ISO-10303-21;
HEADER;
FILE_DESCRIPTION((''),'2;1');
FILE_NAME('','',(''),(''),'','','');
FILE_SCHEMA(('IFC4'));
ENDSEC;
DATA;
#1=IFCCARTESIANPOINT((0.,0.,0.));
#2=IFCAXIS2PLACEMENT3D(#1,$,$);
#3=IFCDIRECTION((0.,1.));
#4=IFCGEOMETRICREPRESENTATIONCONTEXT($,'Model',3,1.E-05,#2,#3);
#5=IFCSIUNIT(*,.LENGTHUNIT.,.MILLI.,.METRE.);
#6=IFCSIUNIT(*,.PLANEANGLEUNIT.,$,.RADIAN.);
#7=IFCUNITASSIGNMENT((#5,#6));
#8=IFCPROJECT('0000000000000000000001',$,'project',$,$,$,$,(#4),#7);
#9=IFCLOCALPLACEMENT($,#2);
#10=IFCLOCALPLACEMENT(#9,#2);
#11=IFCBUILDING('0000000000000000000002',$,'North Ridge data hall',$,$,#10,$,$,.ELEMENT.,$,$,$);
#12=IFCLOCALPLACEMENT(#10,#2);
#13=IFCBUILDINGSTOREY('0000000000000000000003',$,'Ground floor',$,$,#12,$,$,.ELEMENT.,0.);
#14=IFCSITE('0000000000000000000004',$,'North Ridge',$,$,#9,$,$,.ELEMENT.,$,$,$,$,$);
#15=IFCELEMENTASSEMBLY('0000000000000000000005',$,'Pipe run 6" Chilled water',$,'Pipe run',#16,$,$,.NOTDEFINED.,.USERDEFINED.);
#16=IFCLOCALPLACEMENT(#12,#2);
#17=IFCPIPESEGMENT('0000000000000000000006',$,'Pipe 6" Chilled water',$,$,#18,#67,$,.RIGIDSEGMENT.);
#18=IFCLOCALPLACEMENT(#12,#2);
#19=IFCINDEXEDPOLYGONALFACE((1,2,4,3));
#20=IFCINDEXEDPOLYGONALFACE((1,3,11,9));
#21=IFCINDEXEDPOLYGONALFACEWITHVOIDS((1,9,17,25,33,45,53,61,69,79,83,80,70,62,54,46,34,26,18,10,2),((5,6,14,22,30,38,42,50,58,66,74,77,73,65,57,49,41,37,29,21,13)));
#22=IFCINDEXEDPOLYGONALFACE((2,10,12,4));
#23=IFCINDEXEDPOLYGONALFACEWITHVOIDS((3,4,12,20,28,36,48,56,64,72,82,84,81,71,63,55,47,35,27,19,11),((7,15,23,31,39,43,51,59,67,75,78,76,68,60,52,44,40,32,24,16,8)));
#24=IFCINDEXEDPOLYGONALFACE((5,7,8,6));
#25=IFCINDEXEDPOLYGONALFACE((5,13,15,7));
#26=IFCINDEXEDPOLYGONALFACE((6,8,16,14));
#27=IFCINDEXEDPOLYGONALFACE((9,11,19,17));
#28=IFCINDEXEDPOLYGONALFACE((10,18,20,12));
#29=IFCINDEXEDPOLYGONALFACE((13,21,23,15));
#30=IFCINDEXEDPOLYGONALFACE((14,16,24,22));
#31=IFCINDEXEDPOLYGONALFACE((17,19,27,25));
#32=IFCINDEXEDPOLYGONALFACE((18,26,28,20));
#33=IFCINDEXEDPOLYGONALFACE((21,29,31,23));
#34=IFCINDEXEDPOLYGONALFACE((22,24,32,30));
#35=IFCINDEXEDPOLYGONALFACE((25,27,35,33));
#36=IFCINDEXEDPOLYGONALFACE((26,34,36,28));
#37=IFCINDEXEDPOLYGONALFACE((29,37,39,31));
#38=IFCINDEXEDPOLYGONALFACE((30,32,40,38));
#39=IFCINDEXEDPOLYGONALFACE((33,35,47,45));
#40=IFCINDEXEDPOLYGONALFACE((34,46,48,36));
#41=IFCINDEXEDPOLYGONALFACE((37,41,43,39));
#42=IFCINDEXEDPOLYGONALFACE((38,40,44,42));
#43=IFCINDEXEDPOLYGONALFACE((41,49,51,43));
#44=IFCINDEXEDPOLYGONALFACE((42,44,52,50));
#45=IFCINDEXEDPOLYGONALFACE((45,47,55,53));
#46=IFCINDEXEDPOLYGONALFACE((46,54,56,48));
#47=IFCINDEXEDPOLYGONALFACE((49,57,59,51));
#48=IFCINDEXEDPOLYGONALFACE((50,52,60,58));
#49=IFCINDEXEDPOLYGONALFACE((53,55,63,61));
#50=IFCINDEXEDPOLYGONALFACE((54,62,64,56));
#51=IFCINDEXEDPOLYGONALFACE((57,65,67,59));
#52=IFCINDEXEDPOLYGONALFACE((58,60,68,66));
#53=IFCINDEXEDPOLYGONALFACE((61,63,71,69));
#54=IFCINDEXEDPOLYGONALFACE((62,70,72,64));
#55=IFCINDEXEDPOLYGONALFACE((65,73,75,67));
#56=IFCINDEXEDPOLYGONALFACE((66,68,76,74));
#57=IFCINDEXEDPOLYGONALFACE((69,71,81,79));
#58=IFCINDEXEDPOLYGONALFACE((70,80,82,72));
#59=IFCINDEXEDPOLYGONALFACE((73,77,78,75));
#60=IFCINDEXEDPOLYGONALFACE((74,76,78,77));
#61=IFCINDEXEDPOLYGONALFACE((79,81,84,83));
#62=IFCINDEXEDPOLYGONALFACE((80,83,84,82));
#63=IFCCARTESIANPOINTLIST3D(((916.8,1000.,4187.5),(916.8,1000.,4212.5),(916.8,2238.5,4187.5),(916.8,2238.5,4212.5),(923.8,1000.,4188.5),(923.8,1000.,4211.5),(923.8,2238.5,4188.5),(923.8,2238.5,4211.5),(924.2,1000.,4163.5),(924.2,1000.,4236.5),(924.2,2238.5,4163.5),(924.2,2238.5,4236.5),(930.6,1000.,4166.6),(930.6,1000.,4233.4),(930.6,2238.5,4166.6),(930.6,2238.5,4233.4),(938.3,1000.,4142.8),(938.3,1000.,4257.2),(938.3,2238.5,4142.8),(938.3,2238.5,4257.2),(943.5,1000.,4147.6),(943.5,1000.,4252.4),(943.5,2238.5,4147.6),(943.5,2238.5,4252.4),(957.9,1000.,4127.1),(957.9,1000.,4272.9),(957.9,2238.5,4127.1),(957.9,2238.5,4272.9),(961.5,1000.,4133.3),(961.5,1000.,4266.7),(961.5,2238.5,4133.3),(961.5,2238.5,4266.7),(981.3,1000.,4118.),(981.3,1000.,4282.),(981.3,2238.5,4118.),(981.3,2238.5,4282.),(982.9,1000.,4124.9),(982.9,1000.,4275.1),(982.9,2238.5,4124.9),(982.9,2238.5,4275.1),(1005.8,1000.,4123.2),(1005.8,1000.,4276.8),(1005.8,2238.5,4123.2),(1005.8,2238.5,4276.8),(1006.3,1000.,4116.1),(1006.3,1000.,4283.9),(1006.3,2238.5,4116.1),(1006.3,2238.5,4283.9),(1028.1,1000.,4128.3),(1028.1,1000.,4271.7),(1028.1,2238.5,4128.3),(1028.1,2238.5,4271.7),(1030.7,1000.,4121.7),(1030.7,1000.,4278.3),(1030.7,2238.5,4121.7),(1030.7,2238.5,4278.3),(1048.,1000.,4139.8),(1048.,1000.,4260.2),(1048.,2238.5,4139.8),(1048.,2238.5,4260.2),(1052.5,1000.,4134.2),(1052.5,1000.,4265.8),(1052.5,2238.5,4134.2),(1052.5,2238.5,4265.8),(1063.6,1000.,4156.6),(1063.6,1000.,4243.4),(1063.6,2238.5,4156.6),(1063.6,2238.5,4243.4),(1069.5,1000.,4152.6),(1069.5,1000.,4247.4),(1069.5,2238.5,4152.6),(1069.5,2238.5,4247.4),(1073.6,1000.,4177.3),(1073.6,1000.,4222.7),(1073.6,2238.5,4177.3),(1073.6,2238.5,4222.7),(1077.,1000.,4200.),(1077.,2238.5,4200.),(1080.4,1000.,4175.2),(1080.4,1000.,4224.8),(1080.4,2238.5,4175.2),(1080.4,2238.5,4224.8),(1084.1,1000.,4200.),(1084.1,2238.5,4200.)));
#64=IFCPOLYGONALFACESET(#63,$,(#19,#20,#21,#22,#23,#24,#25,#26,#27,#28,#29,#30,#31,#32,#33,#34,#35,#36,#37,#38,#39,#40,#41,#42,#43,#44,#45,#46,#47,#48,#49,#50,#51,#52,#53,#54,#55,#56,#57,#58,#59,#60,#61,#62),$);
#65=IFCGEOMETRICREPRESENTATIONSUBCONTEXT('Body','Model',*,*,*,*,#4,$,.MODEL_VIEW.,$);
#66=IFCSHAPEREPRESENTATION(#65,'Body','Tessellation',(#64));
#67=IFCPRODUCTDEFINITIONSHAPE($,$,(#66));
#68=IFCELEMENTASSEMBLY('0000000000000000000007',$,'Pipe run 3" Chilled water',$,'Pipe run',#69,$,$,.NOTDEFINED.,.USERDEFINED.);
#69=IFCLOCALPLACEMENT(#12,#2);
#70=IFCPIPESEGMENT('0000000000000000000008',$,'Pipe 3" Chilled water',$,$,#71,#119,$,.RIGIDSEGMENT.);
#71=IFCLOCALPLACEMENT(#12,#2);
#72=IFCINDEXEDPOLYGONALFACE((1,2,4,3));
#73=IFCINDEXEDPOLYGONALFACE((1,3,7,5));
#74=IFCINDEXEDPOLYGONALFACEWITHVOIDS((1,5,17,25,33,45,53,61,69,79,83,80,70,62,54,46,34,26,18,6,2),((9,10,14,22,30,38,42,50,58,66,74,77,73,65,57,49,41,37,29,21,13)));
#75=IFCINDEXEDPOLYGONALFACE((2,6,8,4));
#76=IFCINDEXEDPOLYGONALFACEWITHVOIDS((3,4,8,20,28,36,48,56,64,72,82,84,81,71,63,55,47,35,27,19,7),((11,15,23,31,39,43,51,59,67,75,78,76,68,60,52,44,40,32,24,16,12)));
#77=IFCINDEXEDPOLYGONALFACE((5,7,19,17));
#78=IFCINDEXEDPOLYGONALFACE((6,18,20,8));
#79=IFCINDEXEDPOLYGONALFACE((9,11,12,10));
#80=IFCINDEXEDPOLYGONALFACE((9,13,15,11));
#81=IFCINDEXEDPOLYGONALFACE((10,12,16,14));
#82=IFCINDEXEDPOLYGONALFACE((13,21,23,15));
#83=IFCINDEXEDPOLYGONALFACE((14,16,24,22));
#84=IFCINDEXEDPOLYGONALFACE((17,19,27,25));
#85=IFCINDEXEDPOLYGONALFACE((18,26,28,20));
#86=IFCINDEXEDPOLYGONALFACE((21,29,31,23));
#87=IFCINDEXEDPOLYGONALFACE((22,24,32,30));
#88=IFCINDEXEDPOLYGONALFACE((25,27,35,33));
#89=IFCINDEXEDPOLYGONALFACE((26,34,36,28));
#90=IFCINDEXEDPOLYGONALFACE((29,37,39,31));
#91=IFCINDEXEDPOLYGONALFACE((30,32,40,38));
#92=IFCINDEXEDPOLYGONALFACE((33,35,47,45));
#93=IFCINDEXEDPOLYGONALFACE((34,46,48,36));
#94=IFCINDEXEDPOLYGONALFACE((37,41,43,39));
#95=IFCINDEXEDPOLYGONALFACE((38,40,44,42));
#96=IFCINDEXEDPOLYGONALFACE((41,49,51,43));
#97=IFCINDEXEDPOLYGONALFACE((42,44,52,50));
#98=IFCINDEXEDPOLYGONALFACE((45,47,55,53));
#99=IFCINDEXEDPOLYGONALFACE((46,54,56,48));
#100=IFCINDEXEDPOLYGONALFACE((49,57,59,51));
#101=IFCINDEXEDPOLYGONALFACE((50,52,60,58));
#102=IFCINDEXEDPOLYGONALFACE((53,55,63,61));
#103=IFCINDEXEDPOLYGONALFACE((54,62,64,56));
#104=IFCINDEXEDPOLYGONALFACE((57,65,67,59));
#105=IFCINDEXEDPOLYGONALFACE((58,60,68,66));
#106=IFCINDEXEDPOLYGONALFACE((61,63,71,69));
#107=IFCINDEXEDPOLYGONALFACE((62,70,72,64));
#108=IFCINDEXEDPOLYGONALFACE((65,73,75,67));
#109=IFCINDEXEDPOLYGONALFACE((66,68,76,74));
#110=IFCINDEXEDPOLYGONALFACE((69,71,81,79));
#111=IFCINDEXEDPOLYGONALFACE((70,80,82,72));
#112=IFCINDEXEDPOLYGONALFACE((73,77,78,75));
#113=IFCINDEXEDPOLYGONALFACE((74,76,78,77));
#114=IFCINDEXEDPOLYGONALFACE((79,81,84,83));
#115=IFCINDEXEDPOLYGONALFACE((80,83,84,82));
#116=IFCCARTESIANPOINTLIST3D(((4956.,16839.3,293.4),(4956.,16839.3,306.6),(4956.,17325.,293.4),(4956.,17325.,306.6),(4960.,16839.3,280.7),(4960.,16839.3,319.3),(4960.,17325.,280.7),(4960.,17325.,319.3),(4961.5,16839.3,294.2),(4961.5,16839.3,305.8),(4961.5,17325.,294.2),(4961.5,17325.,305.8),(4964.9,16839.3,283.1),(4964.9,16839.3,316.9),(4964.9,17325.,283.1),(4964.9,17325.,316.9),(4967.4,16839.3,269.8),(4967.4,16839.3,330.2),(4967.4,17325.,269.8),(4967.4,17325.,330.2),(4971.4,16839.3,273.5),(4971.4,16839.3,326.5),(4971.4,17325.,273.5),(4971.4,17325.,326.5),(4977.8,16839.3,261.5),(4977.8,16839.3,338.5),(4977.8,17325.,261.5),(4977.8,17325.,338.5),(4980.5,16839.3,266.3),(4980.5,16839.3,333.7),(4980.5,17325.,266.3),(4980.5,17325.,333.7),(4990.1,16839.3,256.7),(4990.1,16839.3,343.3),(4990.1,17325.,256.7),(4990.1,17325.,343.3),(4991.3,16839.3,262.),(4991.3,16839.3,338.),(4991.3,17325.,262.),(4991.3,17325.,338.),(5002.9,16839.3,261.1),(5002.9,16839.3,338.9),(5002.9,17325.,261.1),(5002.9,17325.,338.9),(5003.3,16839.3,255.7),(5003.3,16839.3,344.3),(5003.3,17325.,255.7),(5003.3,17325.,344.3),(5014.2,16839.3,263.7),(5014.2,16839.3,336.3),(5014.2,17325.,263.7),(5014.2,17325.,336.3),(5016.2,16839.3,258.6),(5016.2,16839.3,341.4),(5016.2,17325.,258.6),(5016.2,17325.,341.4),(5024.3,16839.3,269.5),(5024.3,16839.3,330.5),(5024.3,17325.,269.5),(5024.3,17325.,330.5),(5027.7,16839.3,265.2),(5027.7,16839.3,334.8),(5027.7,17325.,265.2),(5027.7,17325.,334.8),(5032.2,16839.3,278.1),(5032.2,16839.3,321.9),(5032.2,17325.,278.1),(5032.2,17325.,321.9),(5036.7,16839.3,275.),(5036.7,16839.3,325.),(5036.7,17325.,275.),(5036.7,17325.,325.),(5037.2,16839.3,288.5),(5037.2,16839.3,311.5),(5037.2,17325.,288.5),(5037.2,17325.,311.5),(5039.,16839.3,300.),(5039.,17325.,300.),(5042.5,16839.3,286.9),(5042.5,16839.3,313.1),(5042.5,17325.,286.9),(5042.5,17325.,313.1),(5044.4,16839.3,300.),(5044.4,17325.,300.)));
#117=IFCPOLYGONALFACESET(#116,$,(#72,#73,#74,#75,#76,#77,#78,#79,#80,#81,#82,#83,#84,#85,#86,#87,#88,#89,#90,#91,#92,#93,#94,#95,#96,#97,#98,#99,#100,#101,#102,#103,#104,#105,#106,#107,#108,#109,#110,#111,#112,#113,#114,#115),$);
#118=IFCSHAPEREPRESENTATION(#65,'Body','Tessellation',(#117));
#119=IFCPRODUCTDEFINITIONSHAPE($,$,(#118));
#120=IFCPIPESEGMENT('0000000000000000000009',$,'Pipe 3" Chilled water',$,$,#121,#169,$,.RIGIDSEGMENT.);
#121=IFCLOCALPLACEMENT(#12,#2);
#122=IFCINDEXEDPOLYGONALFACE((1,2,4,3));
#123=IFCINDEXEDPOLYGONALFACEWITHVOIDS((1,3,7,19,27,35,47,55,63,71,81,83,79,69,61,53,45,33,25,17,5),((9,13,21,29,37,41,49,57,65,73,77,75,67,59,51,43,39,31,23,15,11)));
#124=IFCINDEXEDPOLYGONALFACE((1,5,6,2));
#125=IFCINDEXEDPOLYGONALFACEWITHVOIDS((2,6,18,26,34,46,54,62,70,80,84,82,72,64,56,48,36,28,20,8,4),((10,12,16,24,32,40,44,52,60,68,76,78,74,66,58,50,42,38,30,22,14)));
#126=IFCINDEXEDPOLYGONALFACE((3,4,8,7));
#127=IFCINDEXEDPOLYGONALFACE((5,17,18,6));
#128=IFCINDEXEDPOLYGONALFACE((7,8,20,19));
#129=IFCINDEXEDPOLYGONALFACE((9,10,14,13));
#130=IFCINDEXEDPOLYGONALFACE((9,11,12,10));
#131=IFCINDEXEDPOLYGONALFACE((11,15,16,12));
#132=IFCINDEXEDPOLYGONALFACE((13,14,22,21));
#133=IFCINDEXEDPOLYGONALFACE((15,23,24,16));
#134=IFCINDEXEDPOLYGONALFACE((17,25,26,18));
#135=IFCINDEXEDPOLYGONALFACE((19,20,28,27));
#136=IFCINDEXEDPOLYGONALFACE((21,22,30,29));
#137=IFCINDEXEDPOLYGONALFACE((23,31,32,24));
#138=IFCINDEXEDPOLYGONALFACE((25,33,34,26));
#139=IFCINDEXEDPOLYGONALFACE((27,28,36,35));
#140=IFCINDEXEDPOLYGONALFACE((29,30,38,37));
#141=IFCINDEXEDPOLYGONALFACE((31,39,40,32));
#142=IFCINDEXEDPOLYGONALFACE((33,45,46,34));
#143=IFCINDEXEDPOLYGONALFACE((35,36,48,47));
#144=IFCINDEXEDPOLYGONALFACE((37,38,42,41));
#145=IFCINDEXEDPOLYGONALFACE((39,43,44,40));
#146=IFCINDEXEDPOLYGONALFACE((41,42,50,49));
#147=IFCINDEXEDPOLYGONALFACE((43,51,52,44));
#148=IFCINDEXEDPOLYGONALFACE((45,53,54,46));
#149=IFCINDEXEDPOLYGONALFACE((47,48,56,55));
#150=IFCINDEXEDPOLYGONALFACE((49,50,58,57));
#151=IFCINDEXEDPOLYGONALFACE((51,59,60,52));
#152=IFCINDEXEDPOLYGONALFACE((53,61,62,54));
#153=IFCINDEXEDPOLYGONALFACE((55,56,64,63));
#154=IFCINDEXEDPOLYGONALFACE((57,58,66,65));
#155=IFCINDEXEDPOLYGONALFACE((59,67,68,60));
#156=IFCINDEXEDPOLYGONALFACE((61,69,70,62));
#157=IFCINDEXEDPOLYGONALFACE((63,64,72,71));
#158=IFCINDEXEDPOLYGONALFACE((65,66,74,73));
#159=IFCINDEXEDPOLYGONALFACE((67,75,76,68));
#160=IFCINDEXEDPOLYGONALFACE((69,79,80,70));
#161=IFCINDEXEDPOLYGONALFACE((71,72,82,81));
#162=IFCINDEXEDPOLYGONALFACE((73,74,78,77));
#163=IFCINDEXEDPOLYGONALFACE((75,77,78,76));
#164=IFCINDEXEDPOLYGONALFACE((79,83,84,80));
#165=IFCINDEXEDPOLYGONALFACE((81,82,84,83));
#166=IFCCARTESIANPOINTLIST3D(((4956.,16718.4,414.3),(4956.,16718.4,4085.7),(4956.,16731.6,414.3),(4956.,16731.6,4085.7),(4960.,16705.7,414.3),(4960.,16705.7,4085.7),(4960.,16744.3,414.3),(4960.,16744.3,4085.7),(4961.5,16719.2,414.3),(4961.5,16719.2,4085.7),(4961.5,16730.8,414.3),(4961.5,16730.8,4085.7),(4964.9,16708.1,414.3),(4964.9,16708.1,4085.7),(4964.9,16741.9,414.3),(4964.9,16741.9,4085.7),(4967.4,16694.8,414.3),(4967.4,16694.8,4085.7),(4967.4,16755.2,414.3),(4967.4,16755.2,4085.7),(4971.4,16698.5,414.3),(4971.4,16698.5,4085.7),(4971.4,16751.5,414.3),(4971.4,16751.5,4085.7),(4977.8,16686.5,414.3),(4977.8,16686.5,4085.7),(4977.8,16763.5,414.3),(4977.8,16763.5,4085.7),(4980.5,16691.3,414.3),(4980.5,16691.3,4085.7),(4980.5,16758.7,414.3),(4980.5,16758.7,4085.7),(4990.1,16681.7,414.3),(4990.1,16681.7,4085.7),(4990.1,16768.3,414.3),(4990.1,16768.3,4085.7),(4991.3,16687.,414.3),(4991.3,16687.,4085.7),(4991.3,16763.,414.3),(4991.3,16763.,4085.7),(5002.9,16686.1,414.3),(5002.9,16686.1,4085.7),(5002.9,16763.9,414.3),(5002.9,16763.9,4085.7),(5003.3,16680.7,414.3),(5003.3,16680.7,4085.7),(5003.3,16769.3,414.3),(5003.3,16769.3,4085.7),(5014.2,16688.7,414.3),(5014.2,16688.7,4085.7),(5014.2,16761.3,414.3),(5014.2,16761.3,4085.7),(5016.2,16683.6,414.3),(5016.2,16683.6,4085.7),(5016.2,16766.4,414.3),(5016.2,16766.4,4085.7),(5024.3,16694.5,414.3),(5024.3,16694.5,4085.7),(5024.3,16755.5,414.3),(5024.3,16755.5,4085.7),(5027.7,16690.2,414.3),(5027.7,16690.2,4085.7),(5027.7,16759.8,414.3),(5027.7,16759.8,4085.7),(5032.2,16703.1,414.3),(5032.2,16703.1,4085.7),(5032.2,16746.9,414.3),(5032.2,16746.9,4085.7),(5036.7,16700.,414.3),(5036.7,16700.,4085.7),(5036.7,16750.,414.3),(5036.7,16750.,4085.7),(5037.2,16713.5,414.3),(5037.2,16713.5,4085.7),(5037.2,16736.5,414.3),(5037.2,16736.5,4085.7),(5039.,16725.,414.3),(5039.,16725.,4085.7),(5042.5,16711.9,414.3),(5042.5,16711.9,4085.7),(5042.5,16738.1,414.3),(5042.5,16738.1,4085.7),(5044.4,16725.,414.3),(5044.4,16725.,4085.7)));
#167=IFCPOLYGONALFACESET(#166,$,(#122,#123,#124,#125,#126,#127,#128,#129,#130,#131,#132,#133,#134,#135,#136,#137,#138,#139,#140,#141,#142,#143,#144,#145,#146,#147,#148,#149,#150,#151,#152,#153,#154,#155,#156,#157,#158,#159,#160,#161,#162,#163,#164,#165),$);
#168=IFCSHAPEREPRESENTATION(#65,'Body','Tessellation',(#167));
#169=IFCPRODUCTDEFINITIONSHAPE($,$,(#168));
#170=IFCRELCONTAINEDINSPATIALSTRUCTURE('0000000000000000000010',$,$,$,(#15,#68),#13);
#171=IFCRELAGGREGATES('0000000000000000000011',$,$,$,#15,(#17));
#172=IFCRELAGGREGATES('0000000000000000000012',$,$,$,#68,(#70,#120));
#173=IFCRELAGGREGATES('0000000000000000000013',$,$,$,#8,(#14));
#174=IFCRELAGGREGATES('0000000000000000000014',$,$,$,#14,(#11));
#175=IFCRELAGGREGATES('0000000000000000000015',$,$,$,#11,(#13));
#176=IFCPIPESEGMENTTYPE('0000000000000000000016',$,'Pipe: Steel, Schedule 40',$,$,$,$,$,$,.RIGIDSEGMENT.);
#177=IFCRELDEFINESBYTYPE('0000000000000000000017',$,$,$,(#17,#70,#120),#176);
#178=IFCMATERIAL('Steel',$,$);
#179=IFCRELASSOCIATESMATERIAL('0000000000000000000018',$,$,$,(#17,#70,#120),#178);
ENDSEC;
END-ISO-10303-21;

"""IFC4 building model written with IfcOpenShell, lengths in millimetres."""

from ifc_helpers import new_model, si_unit, direction, frame, origin, origin_with_axes, origin_2d, place, context, subcontext, project, spatial, hollow_circle, extrude, material, type_object, element, aggregate, save


model = new_model("IFC4")

# Units and contexts
model_context = context("Model", 3, precision=1e-05, world=origin(), true_north=direction((0.0, 1.0)))
body_context = subcontext(model_context, "Body", "Model", "MODEL_VIEW")
ifc_project = project(units=[si_unit("LENGTHUNIT", "METRE", prefix="MILLI"), si_unit("PLANEANGLEUNIT", "RADIAN")], contexts=[model_context])

# Site, building, storey
site_placement = place(None, origin())
site = spatial("IfcSite", under=ifc_project, at=site_placement, Name="North Ridge", CompositionType="ELEMENT")
building_placement = place(site_placement, origin())
building = spatial("IfcBuilding", under=site, at=building_placement, Name="North Ridge data hall", CompositionType="ELEMENT")
storey_placement = place(building_placement, origin())
storey = spatial("IfcBuildingStorey", under=building, at=storey_placement, Name="Ground floor", CompositionType="ELEMENT", Elevation=0.0)

# Element assemblies, pipe segments
assembly_1_placement = place(storey_placement, origin_with_axes())
assembly_1 = element("IfcElementAssembly", 1, at=assembly_1_placement, inside=storey, Name="Pipe run 6\" Chilled water", ObjectType="Pipe run", AssemblyPlace="NOTDEFINED", PredefinedType="USERDEFINED")
ifc_material_1 = material(Name="Steel")
pipe_segment_type = type_object("IfcPipeSegmentType", Name="Pipe: Steel, Schedule 40", PredefinedType="RIGIDSEGMENT")
pipe_segment_1_placement = place(storey_placement, origin_with_axes())
pipe_segment_1 = element("IfcPipeSegment", 2, at=pipe_segment_1_placement, type_object=pipe_segment_type, material=ifc_material_1, Name="Pipe 6\" Chilled water", PredefinedType="RIGIDSEGMENT", context=body_context, shape_type="SweptSolid", body=[
    extrude(hollow_circle(Radius=84.1, WallThickness=7.1, at=origin_2d()), frame((1000.0, 2238.5, 4200.0), z_axis=(0.0, -1.0, 0.0), x_axis=(1.0, 0.0, 0.0)), (0.0, 0.0, 1.0), 1238.5),
])
assembly_2_placement = place(storey_placement, origin_with_axes())
assembly_2 = element("IfcElementAssembly", 3, at=assembly_2_placement, inside=storey, Name="Pipe run 3\" Chilled water", ObjectType="Pipe run", AssemblyPlace="NOTDEFINED", PredefinedType="USERDEFINED")
pipe_segment_2_placement = place(storey_placement, origin_with_axes())
pipe_segment_2 = element("IfcPipeSegment", 4, at=pipe_segment_2_placement, type_object=pipe_segment_type, material=ifc_material_1, Name="Pipe 3\" Chilled water", PredefinedType="RIGIDSEGMENT", context=body_context, shape_type="SweptSolid", body=[
    extrude(hollow_circle(Radius=44.5, WallThickness=5.5, at=origin_2d()), frame((5000.0, 17325.0, 300.0), z_axis=(0.0, -1.0, 0.0), x_axis=(1.0, 0.0, 0.0)), (0.0, 0.0, 1.0), 485.7),
])
pipe_segment_3_placement = place(storey_placement, origin_with_axes())
pipe_segment_3 = element("IfcPipeSegment", 5, at=pipe_segment_3_placement, type_object=pipe_segment_type, material=ifc_material_1, Name="Pipe 3\" Chilled water", PredefinedType="RIGIDSEGMENT", context=body_context, shape_type="SweptSolid", body=[
    extrude(hollow_circle(Radius=44.5, WallThickness=5.5, at=origin_2d()), frame((5000.0, 16725.0, 414.3), z_axis=(0.0, 0.0, 1.0), x_axis=(1.0, 0.0, 0.0)), (0.0, 0.0, 1.0), 3671.4),
])

aggregate(assembly_1, [pipe_segment_1])
aggregate(assembly_2, [pipe_segment_2, pipe_segment_3])

save(model, "model.ifc")
